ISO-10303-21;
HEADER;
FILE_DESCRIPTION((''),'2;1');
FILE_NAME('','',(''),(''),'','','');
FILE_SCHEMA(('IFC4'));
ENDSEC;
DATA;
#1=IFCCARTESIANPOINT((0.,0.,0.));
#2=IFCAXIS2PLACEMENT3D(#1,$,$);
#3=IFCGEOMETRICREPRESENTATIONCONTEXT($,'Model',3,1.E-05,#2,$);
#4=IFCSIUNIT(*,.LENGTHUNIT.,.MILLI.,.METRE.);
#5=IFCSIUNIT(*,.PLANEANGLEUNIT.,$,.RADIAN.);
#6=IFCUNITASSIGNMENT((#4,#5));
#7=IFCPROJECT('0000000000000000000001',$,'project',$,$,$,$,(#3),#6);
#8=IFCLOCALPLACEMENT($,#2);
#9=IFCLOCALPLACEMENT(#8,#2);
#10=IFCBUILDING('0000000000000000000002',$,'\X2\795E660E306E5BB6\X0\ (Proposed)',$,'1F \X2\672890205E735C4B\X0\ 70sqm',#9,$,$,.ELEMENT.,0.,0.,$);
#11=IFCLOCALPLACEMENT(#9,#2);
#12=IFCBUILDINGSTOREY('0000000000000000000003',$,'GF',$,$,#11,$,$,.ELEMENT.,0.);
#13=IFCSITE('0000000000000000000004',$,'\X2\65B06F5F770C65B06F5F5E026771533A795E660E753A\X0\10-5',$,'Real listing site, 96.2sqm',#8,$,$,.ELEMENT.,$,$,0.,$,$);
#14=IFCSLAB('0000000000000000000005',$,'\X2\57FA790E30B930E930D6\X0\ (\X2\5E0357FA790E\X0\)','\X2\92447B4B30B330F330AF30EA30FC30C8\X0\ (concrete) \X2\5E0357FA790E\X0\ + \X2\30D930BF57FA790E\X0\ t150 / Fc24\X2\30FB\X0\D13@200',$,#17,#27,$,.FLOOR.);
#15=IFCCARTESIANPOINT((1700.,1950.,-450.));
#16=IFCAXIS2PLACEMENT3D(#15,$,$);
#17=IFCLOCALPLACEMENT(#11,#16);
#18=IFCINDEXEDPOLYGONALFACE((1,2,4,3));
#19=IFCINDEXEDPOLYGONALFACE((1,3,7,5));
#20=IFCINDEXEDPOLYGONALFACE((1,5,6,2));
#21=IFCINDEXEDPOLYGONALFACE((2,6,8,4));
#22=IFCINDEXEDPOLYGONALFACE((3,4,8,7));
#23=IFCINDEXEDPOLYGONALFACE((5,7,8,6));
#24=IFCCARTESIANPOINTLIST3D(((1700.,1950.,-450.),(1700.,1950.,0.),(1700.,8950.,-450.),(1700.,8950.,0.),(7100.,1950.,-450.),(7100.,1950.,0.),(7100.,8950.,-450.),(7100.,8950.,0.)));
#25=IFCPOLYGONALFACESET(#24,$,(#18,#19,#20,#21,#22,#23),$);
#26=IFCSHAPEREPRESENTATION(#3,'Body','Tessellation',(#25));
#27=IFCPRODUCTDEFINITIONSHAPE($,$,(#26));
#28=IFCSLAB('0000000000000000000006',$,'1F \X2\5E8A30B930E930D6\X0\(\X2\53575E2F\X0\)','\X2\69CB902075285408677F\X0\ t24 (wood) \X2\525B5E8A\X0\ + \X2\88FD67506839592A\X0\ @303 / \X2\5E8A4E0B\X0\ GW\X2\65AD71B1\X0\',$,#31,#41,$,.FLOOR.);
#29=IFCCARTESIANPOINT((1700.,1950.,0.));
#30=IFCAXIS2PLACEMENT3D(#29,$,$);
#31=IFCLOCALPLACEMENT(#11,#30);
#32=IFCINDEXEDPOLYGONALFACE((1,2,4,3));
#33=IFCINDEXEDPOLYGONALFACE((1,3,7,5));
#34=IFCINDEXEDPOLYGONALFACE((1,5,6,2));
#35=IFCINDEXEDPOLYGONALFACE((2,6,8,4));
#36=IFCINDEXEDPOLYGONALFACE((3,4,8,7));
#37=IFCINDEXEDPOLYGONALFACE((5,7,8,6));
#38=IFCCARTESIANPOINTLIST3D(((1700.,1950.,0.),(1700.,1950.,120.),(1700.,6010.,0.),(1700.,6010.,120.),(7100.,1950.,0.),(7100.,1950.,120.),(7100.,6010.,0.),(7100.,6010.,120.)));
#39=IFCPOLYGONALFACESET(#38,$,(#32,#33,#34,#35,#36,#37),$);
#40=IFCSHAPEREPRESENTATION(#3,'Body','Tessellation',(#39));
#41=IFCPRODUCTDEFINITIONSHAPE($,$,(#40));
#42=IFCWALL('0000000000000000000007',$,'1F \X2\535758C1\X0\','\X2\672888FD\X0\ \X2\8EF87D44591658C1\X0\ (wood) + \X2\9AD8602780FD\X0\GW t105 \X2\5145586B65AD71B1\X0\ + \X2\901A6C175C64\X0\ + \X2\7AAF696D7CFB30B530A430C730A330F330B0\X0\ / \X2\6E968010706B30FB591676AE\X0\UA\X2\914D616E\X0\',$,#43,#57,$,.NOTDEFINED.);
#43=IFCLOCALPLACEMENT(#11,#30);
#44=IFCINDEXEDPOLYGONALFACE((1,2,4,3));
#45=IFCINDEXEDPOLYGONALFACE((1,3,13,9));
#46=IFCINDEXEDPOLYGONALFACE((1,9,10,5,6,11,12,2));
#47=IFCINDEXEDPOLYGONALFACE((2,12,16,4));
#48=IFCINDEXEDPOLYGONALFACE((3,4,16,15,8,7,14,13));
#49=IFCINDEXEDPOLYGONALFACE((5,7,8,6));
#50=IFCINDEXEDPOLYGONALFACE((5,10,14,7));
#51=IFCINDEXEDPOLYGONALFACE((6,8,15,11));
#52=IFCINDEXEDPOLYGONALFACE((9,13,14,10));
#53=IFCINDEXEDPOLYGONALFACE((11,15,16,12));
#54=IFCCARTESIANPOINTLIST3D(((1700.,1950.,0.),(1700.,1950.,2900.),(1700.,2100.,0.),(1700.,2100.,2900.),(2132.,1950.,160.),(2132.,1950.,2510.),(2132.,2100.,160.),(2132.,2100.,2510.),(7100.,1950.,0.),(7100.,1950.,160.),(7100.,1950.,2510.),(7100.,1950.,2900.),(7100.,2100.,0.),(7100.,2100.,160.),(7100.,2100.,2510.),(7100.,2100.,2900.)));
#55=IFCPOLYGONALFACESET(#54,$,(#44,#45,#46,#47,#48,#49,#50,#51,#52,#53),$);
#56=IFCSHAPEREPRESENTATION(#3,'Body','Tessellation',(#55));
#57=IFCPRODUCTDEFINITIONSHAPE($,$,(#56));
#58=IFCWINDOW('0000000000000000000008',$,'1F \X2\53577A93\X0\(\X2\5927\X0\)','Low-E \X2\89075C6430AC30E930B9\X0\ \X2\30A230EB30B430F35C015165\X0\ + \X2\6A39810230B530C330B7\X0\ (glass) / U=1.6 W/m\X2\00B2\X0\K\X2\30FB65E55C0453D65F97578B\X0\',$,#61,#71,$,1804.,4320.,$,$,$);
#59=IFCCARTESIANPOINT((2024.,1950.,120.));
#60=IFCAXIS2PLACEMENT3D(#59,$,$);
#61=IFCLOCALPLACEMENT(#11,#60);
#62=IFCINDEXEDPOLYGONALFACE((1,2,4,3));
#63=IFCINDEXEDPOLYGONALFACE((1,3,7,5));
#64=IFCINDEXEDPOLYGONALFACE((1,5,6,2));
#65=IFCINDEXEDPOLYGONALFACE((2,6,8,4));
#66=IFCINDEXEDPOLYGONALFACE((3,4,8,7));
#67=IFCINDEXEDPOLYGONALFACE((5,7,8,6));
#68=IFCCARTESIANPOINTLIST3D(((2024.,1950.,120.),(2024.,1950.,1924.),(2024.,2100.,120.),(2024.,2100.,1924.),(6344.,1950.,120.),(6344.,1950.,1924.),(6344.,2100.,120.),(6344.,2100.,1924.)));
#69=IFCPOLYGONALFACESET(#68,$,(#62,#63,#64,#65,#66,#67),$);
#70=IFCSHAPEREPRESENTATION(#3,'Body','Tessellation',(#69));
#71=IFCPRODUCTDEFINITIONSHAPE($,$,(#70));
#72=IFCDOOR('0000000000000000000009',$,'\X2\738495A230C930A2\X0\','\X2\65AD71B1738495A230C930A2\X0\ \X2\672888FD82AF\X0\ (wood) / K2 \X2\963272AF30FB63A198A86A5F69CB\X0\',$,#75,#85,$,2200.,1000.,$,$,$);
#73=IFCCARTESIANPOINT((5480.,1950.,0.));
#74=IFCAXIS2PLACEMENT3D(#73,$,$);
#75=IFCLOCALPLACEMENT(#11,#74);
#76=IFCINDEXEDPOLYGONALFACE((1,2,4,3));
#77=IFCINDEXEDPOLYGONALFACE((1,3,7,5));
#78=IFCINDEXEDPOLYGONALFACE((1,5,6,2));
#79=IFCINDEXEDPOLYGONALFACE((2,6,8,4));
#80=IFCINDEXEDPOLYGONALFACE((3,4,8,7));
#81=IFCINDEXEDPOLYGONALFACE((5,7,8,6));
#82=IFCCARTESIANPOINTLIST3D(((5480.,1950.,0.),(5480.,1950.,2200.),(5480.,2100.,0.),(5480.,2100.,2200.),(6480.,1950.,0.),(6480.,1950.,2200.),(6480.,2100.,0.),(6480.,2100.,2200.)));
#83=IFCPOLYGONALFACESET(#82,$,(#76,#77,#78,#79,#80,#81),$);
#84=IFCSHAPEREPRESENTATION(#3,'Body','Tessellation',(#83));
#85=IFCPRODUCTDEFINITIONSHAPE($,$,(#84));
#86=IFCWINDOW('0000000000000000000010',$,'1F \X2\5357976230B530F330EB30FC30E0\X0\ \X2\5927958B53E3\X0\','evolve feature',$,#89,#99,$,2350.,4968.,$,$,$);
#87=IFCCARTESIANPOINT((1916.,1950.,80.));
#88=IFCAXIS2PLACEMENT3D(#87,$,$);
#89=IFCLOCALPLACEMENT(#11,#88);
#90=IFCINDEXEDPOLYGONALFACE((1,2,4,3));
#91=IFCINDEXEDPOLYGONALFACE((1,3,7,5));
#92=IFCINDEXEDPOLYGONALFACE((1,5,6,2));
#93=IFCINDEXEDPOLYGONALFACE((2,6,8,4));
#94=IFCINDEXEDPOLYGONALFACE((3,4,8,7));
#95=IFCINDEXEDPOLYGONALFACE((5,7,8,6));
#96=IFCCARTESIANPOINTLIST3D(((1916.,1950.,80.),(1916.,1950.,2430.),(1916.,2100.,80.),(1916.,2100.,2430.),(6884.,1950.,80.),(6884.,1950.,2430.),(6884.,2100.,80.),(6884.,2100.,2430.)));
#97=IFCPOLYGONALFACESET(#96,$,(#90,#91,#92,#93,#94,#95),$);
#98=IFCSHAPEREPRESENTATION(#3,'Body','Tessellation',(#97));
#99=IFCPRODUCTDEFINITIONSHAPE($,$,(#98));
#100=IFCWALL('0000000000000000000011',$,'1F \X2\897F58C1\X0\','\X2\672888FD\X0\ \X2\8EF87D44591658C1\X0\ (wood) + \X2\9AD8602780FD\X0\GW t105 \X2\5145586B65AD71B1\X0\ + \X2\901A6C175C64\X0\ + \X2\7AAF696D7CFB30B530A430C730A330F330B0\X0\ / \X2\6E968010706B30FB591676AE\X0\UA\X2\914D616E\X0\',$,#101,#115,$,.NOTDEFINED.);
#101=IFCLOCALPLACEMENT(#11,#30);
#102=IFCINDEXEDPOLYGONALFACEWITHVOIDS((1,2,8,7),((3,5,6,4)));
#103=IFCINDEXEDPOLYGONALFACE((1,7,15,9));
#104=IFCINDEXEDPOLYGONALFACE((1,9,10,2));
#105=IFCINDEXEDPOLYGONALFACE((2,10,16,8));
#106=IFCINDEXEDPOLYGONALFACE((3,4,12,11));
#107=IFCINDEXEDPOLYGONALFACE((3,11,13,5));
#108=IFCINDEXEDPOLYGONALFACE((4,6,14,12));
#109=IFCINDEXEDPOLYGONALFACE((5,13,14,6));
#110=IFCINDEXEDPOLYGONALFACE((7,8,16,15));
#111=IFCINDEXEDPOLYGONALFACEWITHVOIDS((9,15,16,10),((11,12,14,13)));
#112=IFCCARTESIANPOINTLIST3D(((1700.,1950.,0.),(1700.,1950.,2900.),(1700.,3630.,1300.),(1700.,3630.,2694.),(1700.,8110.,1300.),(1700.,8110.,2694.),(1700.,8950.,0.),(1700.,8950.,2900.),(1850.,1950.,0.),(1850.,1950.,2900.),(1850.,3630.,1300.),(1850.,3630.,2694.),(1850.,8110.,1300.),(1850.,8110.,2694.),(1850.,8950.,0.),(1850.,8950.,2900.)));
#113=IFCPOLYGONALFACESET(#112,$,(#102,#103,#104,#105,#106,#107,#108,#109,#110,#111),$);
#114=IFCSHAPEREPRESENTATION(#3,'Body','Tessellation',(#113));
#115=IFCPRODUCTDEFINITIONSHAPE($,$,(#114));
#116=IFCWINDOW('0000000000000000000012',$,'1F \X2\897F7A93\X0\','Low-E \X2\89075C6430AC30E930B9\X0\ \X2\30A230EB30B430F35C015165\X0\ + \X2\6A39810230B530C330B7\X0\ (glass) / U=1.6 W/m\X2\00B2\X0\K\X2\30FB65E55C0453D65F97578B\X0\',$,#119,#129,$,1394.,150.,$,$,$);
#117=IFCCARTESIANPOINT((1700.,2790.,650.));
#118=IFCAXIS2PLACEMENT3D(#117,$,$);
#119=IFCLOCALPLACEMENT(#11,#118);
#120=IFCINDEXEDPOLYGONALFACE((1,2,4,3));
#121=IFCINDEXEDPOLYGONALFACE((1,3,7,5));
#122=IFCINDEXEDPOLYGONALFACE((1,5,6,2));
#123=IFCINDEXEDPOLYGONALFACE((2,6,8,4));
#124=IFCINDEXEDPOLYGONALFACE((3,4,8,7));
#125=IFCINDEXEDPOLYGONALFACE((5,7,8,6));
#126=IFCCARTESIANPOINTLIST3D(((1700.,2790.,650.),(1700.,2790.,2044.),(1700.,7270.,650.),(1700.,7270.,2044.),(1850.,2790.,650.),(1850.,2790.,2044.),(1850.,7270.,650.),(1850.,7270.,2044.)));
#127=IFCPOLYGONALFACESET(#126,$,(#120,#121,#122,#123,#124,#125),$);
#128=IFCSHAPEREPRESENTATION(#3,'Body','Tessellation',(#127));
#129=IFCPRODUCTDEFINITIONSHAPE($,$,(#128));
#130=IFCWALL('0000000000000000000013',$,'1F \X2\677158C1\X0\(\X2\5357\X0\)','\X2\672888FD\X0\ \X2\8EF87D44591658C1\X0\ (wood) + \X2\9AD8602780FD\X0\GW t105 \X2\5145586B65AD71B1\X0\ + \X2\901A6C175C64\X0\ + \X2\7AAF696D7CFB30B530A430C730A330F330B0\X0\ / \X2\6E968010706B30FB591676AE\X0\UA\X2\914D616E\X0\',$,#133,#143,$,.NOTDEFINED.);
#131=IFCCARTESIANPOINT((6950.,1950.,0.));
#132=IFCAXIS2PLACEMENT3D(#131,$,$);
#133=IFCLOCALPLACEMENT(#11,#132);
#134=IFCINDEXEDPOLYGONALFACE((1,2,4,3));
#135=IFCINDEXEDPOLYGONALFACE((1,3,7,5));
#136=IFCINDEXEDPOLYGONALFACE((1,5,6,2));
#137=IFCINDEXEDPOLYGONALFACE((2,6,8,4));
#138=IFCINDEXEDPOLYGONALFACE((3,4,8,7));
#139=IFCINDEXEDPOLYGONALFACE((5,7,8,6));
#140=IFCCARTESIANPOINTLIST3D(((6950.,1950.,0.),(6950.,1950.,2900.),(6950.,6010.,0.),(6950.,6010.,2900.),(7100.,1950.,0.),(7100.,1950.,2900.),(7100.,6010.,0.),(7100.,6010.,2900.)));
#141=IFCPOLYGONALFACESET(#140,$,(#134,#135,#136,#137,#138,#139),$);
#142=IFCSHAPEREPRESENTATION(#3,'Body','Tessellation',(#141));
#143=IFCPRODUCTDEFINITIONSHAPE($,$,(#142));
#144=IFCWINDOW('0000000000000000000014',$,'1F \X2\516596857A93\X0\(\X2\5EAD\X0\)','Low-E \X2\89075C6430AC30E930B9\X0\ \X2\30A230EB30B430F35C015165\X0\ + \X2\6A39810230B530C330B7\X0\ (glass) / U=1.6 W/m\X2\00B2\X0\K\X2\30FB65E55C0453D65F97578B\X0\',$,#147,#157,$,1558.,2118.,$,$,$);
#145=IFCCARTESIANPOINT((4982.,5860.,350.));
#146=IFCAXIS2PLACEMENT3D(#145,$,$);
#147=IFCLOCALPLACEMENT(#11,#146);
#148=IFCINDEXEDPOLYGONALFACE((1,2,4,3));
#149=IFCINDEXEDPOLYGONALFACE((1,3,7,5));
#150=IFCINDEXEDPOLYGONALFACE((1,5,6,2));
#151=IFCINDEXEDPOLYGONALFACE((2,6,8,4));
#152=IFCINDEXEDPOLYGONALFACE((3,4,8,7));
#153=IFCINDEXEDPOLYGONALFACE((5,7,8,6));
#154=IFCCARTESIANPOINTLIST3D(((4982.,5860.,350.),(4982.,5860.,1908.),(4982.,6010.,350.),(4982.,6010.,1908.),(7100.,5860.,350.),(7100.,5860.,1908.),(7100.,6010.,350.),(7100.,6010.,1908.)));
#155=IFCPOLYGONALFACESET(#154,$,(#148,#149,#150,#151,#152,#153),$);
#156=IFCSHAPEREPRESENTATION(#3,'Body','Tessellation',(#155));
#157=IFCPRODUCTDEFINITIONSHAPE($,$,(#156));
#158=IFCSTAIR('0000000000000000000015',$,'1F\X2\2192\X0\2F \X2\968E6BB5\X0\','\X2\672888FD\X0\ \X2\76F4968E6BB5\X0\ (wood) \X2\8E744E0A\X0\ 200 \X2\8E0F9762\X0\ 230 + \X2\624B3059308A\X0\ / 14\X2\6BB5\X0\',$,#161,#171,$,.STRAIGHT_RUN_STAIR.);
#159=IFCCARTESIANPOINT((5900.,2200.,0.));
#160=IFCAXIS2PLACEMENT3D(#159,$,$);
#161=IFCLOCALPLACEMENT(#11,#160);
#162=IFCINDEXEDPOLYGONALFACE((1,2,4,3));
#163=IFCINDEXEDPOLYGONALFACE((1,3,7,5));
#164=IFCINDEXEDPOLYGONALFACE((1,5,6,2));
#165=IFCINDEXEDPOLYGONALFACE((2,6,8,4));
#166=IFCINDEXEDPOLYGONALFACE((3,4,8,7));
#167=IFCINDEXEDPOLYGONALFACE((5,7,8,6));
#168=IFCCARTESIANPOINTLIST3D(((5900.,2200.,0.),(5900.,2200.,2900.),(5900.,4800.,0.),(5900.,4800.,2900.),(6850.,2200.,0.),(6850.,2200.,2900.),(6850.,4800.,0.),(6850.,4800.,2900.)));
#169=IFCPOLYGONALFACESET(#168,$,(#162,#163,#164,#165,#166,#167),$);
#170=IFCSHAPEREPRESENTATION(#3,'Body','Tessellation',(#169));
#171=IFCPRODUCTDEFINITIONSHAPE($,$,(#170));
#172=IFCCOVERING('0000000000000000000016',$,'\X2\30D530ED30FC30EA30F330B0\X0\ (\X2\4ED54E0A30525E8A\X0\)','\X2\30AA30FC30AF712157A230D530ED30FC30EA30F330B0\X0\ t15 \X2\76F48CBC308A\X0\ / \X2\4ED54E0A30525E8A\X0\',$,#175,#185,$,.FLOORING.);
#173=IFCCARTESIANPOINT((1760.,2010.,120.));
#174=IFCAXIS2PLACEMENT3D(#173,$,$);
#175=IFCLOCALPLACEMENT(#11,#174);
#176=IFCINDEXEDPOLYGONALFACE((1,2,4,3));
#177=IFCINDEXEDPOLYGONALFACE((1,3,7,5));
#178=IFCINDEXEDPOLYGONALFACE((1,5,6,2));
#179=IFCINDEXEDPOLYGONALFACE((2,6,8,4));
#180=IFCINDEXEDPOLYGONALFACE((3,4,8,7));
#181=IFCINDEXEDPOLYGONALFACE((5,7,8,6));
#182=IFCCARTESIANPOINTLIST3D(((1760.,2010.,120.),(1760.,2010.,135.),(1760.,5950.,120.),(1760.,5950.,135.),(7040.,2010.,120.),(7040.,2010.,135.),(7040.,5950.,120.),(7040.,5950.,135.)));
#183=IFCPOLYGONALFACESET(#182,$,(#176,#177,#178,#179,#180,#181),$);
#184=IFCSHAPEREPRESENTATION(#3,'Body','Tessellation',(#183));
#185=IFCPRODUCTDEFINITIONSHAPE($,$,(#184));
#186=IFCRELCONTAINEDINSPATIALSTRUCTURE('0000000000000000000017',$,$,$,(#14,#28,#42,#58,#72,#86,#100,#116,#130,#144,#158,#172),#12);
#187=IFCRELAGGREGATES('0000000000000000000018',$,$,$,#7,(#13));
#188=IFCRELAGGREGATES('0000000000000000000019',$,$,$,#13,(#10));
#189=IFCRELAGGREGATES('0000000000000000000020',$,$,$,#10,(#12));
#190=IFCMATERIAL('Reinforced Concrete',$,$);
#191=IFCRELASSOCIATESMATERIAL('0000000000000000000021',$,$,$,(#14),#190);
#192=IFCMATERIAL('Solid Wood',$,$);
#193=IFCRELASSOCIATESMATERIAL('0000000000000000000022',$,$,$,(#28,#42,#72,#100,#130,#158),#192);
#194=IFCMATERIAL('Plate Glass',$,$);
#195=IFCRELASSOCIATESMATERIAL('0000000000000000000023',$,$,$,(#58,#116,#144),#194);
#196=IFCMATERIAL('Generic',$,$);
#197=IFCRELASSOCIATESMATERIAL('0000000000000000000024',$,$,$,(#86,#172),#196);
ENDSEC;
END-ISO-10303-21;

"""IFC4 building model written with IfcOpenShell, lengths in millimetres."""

from ifc_helpers import new_model, si_unit, frame, frame_2d, origin, place, context, project, spatial, rectangle, extrude, material, element, fill, save


model = new_model("IFC4")

# Units and contexts
model_context = context("Model", 3, precision=1e-05, world=origin())
ifc_project = project(units=[si_unit("LENGTHUNIT", "METRE", prefix="MILLI"), si_unit("PLANEANGLEUNIT", "RADIAN")], contexts=[model_context])

# Site, building, storey
site_placement = place(None, origin())
site = spatial("IfcSite", under=ifc_project, at=site_placement, Name="新潟県新潟市東区神明町10-5", ObjectType="Real listing site, 96.2sqm", CompositionType="ELEMENT", RefElevation=0.0)
building_placement = place(site_placement, origin())
building = spatial("IfcBuilding", under=site, at=building_placement, Name="神明の家 (Proposed)", ObjectType="1F 木造平屋 70sqm", CompositionType="ELEMENT", ElevationOfRefHeight=0.0, ElevationOfTerrain=0.0)
storey_placement = place(building_placement, origin())
storey = spatial("IfcBuildingStorey", under=building, at=storey_placement, Name="GF", CompositionType="ELEMENT", Elevation=0.0)

# Slabs
ifc_material_1 = material(Name="Reinforced Concrete")
slab_1_placement = place(storey_placement, frame((1700.0, 1950.0, -450.0)))
element("IfcSlab", 1, at=slab_1_placement, inside=storey, material=ifc_material_1, Name="基礎スラブ (布基礎)", Description="鉄筋コンクリート (concrete) 布基礎 + ベタ基礎 t150 / Fc24・D13@200", PredefinedType="FLOOR", context=model_context, shape_type="SweptSolid", body=[
    extrude(rectangle(XDim=5400.0, YDim=7000.0, at=frame_2d((2700.0, 3500.0))), frame((1700.0, 1950.0, -450.0)), (0.0, 0.0, 1.0), 450.0),
])
ifc_material_2 = material(Name="Solid Wood")
slab_2_placement = place(storey_placement, frame((1700.0, 1950.0, 0.0)))
element("IfcSlab", 2, at=slab_2_placement, inside=storey, material=ifc_material_2, Name="1F 床スラブ(南帯)", Description="構造用合板 t24 (wood) 剛床 + 製材根太 @303 / 床下 GW断熱", PredefinedType="FLOOR", context=model_context, shape_type="SweptSolid", body=[
    extrude(rectangle(XDim=5400.0, YDim=4060.0, at=frame_2d((2700.0, 2030.0))), frame((1700.0, 1950.0, 0.0)), (0.0, 0.0, 1.0), 120.0),
])

# Wall, openings, windows, door
wall_1_placement = place(storey_placement, frame((1700.0, 1950.0, 0.0)))
wall_1 = element("IfcWall", 3, at=wall_1_placement, inside=storey, material=ifc_material_2, Name="1F 南壁", Description="木製 軸組外壁 (wood) + 高性能GW t105 充填断熱 + 通気層 + 窯業系サイディング / 準耐火・外皮UA配慮", PredefinedType="NOTDEFINED", context=model_context, shape_type="SweptSolid", body=[
    extrude(rectangle(XDim=5400.0, YDim=150.0, at=frame_2d((2700.0, 75.0))), frame((1700.0, 1950.0, 0.0)), (0.0, 0.0, 1.0), 2900.0),
])
opening_1_placement = place(storey_placement, frame((2024.0, 1950.0, 120.0)))
opening_1 = element("IfcOpeningElement", 4, at=opening_1_placement, cuts=wall_1, PredefinedType="NOTDEFINED", context=model_context, shape_type="SweptSolid", body=[
    extrude(rectangle(XDim=4320.0, YDim=150.0, at=frame_2d((2160.0, 75.0))), frame((2024.0, 1950.0, 120.0)), (0.0, 0.0, 1.0), 1804.0),
])
opening_2_placement = place(storey_placement, frame((5480.0, 1950.0, 0.0)))
opening_2 = element("IfcOpeningElement", 5, at=opening_2_placement, cuts=wall_1, PredefinedType="NOTDEFINED", context=model_context, shape_type="SweptSolid", body=[
    extrude(rectangle(XDim=1000.0, YDim=150.0, at=frame_2d((500.0, 75.0))), frame((5480.0, 1950.0, 0.0)), (0.0, 0.0, 1.0), 2200.0),
])
opening_3_placement = place(storey_placement, frame((1916.0, 1950.0, 80.0)))
opening_3 = element("IfcOpeningElement", 6, at=opening_3_placement, cuts=wall_1, PredefinedType="NOTDEFINED", context=model_context, shape_type="SweptSolid", body=[
    extrude(rectangle(XDim=4968.0, YDim=150.0, at=frame_2d((2484.0, 75.0))), frame((1916.0, 1950.0, 80.0)), (0.0, 0.0, 1.0), 2350.0),
])
ifc_material_3 = material(Name="Plate Glass")
window_1_placement = place(storey_placement, frame((2024.0, 1950.0, 120.0)))
window_1 = element("IfcWindow", 7, at=window_1_placement, inside=storey, material=ifc_material_3, Name="1F 南窓(大)", Description="Low-E 複層ガラス アルゴン封入 + 樹脂サッシ (glass) / U=1.6 W/m²K・日射取得型", OverallHeight=1804.0, OverallWidth=4320.0, context=model_context, shape_type="SweptSolid", body=[
    extrude(rectangle(XDim=4320.0, YDim=150.0, at=frame_2d((2160.0, 75.0))), frame((2024.0, 1950.0, 120.0)), (0.0, 0.0, 1.0), 1804.0),
])
fill(opening_1, window_1)
door_1_placement = place(storey_placement, frame((5480.0, 1950.0, 0.0)))
door_1 = element("IfcDoor", 8, at=door_1_placement, inside=storey, material=ifc_material_2, Name="玄関ドア", Description="断熱玄関ドア 木製芯 (wood) / K2 防犯・採風機構", OverallHeight=2200.0, OverallWidth=1000.0, context=model_context, shape_type="SweptSolid", body=[
    extrude(rectangle(XDim=1000.0, YDim=150.0, at=frame_2d((500.0, 75.0))), frame((5480.0, 1950.0, 0.0)), (0.0, 0.0, 1.0), 2200.0),
])
fill(opening_2, door_1)
ifc_material_4 = material(Name="Generic")
window_2_placement = place(storey_placement, frame((1916.0, 1950.0, 80.0)))
window_2 = element("IfcWindow", 9, at=window_2_placement, inside=storey, material=ifc_material_4, Name="1F 南面サンルーム 大開口", Description="evolve feature", OverallHeight=2350.0, OverallWidth=4968.0, context=model_context, shape_type="SweptSolid", body=[
    extrude(rectangle(XDim=4968.0, YDim=150.0, at=frame_2d((2484.0, 75.0))), frame((1916.0, 1950.0, 80.0)), (0.0, 0.0, 1.0), 2350.0),
])
fill(opening_3, window_2)

# Walls, openings, windows
wall_2_placement = place(storey_placement, frame((1700.0, 1950.0, 0.0)))
wall_2 = element("IfcWall", 10, at=wall_2_placement, inside=storey, material=ifc_material_2, Name="1F 西壁", Description="木製 軸組外壁 (wood) + 高性能GW t105 充填断熱 + 通気層 + 窯業系サイディング / 準耐火・外皮UA配慮", PredefinedType="NOTDEFINED", context=model_context, shape_type="SweptSolid", body=[
    extrude(rectangle(XDim=150.0, YDim=7000.0, at=frame_2d((75.0, 3500.0))), frame((1700.0, 1950.0, 0.0)), (0.0, 0.0, 1.0), 2900.0),
])
opening_4_placement = place(storey_placement, frame((1700.0, 2790.0, 650.0)))
opening_4 = element("IfcOpeningElement", 11, at=opening_4_placement, cuts=wall_2, PredefinedType="NOTDEFINED", context=model_context, shape_type="SweptSolid", body=[
    extrude(rectangle(XDim=150.0, YDim=4480.0, at=frame_2d((75.0, 2240.0))), frame((1700.0, 2790.0, 650.0)), (0.0, 0.0, 1.0), 1394.0),
])
window_3_placement = place(storey_placement, frame((1700.0, 2790.0, 650.0)))
window_3 = element("IfcWindow", 12, at=window_3_placement, inside=storey, material=ifc_material_3, Name="1F 西窓", Description="Low-E 複層ガラス アルゴン封入 + 樹脂サッシ (glass) / U=1.6 W/m²K・日射取得型", OverallHeight=1394.0, OverallWidth=150.0, context=model_context, shape_type="SweptSolid", body=[
    extrude(rectangle(XDim=150.0, YDim=4480.0, at=frame_2d((75.0, 2240.0))), frame((1700.0, 2790.0, 650.0)), (0.0, 0.0, 1.0), 1394.0),
])
fill(opening_4, window_3)
wall_3_placement = place(storey_placement, frame((6950.0, 1950.0, 0.0)))
wall_3 = element("IfcWall", 13, at=wall_3_placement, inside=storey, material=ifc_material_2, Name="1F 東壁(南)", Description="木製 軸組外壁 (wood) + 高性能GW t105 充填断熱 + 通気層 + 窯業系サイディング / 準耐火・外皮UA配慮", PredefinedType="NOTDEFINED", context=model_context, shape_type="SweptSolid", body=[
    extrude(rectangle(XDim=150.0, YDim=4060.0, at=frame_2d((75.0, 2030.0))), frame((6950.0, 1950.0, 0.0)), (0.0, 0.0, 1.0), 2900.0),
])
opening_5_placement = place(storey_placement, frame((4982.0, 5860.0, 350.0)))
opening_5 = element("IfcOpeningElement", 14, at=opening_5_placement, cuts=wall_3, PredefinedType="NOTDEFINED", context=model_context, shape_type="SweptSolid", body=[
    extrude(rectangle(XDim=2118.0, YDim=150.0, at=frame_2d((1059.0, 75.0))), frame((4982.0, 5860.0, 350.0)), (0.0, 0.0, 1.0), 1558.0),
])
window_4_placement = place(storey_placement, frame((4982.0, 5860.0, 350.0)))
window_4 = element("IfcWindow", 15, at=window_4_placement, inside=storey, material=ifc_material_3, Name="1F 入隅窓(庭)", Description="Low-E 複層ガラス アルゴン封入 + 樹脂サッシ (glass) / U=1.6 W/m²K・日射取得型", OverallHeight=1558.0, OverallWidth=2118.0, context=model_context, shape_type="SweptSolid", body=[
    extrude(rectangle(XDim=2118.0, YDim=150.0, at=frame_2d((1059.0, 75.0))), frame((4982.0, 5860.0, 350.0)), (0.0, 0.0, 1.0), 1558.0),
])
fill(opening_5, window_4)

# Stair
stair_placement = place(storey_placement, frame((5900.0, 2200.0, 0.0)))
element("IfcStair", 16, at=stair_placement, inside=storey, material=ifc_material_2, Name="1F→2F 階段", Description="木製 直階段 (wood) 蹴上 200 踏面 230 + 手すり / 14段", PredefinedType="STRAIGHT_RUN_STAIR", context=model_context, shape_type="SweptSolid", body=[
    extrude(rectangle(XDim=950.0, YDim=2600.0, at=frame_2d((475.0, 1300.0))), frame((5900.0, 2200.0, 0.0)), (0.0, 0.0, 1.0), 2900.0),
])

# Covering
covering_placement = place(storey_placement, frame((1760.0, 2010.0, 120.0)))
element("IfcCovering", 17, at=covering_placement, inside=storey, material=ifc_material_4, Name="フローリング (仕上げ床)", Description="オーク無垢フローリング t15 直貼り / 仕上げ床", PredefinedType="FLOORING", context=model_context, shape_type="SweptSolid", body=[
    extrude(rectangle(XDim=5280.0, YDim=3940.0, at=frame_2d((2640.0, 1970.0))), frame((1760.0, 2010.0, 120.0)), (0.0, 0.0, 1.0), 15.0),
])

save(model, "model.ifc")
